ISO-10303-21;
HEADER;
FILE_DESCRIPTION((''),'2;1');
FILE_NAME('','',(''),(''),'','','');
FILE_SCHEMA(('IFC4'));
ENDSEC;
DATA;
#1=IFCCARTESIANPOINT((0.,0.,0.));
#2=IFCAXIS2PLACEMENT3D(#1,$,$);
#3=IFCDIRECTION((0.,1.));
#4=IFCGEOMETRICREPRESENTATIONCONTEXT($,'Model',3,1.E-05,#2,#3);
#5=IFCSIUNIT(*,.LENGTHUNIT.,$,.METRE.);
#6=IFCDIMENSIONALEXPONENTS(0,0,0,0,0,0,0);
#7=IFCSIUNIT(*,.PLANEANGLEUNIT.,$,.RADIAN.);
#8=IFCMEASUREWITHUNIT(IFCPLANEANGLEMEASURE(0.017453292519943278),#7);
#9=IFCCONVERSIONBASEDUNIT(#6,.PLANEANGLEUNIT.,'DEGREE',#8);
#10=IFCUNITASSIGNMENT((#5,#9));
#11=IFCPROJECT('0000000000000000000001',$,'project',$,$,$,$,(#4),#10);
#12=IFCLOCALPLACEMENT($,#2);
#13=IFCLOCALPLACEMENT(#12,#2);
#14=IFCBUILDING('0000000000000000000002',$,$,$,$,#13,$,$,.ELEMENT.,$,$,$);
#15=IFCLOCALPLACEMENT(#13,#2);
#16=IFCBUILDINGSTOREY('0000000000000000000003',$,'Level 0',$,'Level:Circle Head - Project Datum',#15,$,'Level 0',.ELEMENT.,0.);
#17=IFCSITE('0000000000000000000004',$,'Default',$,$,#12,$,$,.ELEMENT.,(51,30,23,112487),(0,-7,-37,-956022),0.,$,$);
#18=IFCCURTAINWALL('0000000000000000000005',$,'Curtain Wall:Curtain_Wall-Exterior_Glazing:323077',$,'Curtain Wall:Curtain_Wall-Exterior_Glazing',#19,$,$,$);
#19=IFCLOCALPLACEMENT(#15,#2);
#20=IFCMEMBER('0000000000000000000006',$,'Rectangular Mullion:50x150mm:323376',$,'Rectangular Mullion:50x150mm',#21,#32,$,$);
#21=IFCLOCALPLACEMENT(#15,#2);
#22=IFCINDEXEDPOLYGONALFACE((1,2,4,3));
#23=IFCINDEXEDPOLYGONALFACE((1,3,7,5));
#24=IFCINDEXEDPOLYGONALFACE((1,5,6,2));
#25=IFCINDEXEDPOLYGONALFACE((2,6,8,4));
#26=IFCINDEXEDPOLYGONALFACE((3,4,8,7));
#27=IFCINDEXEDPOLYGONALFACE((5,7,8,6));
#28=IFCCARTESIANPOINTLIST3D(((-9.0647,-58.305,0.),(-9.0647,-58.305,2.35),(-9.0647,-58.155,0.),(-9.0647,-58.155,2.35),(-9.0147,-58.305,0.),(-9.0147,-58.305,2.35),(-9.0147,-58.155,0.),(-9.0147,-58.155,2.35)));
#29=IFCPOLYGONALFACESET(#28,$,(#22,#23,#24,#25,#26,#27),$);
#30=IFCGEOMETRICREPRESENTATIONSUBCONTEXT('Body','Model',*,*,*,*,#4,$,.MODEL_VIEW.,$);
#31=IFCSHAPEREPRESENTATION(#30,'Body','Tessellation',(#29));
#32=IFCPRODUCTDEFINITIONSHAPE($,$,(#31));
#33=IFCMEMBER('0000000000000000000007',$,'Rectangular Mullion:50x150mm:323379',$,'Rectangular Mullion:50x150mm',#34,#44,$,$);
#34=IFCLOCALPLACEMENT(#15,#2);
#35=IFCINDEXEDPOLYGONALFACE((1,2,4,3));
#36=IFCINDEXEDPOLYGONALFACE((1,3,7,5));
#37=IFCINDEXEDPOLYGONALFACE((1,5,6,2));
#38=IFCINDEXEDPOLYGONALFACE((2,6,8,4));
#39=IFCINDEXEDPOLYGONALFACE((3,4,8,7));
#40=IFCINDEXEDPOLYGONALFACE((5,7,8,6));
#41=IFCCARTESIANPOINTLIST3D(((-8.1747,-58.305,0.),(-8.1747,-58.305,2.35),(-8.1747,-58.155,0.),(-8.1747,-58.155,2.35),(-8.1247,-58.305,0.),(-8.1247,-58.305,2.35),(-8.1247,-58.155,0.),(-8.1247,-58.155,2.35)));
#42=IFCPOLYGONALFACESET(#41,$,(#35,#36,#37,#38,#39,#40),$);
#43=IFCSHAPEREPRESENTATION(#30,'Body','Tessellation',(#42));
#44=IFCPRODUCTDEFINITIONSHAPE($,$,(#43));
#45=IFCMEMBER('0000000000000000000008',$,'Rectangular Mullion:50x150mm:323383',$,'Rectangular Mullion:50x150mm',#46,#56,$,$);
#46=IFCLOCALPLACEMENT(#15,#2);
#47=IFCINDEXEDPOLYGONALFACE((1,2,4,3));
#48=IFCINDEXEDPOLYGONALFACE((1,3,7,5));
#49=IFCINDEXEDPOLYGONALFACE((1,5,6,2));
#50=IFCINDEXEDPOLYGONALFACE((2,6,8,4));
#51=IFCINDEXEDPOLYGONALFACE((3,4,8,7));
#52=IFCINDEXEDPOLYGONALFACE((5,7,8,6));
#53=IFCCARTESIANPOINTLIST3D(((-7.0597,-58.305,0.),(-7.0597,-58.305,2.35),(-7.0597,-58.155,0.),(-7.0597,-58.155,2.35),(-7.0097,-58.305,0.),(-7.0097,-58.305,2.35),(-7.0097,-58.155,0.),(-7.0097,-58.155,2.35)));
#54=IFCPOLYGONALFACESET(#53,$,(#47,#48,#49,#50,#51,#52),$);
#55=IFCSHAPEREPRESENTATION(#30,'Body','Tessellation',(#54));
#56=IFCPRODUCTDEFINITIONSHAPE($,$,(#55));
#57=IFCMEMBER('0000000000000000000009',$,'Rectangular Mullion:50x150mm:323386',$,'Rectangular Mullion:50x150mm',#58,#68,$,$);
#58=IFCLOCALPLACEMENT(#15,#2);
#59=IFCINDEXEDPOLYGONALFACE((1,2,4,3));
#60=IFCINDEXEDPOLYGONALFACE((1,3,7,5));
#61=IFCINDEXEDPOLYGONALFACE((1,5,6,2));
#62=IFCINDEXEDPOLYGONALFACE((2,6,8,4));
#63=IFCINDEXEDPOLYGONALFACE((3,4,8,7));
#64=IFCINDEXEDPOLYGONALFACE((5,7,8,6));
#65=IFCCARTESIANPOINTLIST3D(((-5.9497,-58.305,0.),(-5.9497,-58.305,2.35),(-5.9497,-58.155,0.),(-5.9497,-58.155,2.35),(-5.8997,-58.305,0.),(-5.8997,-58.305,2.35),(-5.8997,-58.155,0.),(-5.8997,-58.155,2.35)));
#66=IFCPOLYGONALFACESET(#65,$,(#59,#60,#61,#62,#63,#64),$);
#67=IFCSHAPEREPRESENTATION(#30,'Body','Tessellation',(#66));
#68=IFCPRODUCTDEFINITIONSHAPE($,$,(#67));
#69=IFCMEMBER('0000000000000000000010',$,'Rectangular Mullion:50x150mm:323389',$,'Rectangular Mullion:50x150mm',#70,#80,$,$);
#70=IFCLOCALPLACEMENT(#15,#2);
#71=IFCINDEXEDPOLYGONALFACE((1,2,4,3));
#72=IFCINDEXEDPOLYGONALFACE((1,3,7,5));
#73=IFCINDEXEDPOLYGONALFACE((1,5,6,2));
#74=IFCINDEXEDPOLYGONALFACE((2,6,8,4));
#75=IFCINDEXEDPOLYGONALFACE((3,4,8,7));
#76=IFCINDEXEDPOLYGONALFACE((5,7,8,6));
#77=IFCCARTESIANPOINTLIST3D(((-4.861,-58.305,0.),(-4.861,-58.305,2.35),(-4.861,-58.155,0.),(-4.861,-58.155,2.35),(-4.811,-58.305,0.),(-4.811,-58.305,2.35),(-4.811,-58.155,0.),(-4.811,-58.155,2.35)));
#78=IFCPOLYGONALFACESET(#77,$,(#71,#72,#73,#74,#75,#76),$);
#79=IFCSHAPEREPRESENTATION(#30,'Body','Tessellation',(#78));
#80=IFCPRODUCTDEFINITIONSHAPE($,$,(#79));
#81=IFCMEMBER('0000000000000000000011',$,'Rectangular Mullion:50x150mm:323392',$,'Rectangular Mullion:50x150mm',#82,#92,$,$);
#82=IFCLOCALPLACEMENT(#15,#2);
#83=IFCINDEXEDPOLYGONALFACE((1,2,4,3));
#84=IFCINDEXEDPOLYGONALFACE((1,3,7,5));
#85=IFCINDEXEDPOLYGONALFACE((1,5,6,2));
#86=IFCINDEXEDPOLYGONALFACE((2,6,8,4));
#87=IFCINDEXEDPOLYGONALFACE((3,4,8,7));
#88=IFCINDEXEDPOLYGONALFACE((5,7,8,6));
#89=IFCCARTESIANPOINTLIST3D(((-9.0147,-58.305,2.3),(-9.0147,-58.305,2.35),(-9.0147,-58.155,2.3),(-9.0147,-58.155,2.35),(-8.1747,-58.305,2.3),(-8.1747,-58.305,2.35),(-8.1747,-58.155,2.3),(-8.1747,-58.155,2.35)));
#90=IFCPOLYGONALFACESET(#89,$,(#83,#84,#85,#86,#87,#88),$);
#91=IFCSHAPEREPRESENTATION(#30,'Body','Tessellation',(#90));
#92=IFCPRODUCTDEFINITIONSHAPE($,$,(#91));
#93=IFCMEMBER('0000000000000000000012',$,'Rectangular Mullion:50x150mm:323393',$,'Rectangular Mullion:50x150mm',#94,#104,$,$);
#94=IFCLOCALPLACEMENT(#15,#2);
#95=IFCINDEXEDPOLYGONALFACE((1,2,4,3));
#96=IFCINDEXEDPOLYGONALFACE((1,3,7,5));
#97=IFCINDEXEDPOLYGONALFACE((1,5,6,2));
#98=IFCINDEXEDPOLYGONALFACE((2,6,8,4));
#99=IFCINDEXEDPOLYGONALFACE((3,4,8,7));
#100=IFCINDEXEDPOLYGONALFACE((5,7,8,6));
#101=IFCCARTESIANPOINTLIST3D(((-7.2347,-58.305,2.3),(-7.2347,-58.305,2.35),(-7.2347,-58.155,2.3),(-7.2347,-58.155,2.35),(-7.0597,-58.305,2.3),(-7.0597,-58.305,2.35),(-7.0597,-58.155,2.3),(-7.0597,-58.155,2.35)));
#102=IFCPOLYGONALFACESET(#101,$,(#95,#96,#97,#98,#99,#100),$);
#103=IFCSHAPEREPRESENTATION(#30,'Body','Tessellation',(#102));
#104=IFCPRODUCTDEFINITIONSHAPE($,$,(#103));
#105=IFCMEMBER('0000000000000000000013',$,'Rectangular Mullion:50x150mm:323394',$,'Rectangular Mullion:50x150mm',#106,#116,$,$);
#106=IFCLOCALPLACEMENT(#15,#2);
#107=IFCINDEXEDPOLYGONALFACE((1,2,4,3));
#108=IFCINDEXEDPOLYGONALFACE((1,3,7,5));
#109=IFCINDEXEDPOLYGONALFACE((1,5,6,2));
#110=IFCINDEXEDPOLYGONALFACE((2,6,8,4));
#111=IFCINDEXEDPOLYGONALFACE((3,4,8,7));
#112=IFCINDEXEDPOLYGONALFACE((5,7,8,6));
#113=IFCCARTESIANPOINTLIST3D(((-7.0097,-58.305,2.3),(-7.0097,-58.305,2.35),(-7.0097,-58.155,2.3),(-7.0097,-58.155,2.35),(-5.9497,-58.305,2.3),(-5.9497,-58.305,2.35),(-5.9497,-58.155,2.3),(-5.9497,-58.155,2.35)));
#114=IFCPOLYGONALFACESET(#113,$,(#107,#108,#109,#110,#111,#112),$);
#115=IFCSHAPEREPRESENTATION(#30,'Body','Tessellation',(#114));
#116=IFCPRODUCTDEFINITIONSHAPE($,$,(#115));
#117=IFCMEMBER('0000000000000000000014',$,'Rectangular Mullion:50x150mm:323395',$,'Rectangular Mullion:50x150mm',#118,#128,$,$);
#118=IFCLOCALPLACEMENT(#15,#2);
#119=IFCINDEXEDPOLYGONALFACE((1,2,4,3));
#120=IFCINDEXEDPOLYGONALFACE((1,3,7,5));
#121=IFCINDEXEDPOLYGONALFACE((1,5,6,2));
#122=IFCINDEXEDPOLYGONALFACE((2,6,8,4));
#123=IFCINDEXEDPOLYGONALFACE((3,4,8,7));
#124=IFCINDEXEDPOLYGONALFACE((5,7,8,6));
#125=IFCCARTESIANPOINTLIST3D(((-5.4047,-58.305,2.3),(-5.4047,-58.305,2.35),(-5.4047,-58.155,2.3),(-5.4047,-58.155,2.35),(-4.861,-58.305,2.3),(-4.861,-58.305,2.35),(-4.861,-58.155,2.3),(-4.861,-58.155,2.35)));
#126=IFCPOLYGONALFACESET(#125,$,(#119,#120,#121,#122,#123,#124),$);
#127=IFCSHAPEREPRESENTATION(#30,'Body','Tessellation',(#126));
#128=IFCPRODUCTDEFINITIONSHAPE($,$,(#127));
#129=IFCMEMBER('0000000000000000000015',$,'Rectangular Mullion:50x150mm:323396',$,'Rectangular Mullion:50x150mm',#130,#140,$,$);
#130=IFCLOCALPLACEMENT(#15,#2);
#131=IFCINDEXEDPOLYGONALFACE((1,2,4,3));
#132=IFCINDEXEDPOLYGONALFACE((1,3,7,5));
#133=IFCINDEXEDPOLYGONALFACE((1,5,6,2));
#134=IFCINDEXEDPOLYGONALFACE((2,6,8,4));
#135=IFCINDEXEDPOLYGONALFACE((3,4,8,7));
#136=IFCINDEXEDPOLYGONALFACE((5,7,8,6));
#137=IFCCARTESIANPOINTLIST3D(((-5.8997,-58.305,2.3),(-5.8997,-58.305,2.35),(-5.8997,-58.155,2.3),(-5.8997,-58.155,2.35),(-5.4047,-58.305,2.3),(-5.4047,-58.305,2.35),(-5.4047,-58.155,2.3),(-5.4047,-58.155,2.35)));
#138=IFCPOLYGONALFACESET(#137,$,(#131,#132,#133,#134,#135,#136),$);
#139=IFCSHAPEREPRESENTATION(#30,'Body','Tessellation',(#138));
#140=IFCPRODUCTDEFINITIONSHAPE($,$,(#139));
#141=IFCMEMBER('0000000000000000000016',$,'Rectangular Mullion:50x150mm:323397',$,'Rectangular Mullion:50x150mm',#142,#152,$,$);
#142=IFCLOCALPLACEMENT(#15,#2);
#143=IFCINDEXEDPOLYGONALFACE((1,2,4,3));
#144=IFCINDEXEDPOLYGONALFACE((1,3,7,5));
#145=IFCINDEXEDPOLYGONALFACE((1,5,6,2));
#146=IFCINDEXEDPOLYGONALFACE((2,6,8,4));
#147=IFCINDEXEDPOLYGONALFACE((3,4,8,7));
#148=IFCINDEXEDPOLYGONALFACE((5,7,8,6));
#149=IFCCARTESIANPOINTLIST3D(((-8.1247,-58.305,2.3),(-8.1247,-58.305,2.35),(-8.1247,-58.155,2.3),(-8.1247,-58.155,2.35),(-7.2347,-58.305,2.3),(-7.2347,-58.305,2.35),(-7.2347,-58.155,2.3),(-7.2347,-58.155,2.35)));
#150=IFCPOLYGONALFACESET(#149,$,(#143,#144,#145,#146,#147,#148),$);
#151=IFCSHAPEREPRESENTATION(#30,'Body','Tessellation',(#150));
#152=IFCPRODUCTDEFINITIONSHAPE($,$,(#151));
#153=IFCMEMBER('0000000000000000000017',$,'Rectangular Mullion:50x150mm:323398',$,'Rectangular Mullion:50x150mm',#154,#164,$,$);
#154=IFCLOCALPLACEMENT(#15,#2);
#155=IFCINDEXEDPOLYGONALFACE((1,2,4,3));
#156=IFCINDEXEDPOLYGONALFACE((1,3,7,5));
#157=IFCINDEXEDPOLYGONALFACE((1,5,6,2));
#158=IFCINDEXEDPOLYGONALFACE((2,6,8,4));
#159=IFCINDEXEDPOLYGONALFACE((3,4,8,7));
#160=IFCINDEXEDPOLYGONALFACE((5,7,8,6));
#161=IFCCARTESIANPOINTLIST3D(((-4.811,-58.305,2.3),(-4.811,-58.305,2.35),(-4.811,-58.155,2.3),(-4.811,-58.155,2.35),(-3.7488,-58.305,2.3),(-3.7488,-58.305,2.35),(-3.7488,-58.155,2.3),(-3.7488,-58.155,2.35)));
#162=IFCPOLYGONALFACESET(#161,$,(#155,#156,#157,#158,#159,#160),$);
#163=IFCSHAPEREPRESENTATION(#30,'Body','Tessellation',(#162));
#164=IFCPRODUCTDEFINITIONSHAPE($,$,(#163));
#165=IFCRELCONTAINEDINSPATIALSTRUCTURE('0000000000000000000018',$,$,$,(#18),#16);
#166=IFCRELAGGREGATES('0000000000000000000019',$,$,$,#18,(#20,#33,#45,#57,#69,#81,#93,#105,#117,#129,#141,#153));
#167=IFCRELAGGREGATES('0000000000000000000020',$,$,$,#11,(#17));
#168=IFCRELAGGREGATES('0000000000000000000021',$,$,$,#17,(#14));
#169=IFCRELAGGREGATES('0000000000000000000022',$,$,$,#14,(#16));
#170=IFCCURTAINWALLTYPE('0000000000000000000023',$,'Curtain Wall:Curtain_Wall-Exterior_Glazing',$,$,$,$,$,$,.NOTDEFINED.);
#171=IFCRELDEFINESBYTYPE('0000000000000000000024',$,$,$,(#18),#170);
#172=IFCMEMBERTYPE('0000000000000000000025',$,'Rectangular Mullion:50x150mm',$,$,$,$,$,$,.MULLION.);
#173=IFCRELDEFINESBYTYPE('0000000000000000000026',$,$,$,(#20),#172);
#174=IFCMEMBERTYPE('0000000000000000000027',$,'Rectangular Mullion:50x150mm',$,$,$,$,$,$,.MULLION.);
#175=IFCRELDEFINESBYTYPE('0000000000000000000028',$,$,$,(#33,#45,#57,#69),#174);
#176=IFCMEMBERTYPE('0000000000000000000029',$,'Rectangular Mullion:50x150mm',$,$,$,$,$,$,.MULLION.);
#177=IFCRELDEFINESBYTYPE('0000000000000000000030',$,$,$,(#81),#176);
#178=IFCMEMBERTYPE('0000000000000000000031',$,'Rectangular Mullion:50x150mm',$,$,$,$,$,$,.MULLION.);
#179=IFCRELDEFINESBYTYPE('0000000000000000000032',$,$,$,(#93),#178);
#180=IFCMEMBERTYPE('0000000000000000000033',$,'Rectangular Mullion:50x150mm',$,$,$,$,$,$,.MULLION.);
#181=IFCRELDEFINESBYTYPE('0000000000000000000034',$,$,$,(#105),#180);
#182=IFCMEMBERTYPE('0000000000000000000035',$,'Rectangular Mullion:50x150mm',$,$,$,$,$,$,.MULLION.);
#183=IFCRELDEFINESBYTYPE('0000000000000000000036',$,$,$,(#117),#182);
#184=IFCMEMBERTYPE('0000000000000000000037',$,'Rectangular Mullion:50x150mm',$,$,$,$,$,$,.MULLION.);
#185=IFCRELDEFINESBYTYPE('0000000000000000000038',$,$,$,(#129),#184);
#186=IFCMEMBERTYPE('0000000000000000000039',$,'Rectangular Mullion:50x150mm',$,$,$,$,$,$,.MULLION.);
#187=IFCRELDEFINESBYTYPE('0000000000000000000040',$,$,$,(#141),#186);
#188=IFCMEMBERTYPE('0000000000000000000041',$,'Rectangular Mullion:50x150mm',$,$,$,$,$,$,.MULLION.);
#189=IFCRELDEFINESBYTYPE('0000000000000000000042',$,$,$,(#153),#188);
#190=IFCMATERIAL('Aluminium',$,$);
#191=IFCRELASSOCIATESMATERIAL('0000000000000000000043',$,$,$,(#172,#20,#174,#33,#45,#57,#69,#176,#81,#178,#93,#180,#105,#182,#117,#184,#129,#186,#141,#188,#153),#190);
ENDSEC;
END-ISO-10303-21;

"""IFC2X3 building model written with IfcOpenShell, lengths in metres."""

from ifc_helpers import new_model, entity, si_unit, converted_unit, direction, frame, origin, origin_2d_with_axis, place, context, subcontext, project, spatial, rectangle, extrude, source, transform, mapped, material, type_object, type_shapes, element, aggregate, save


model = new_model("IFC2X3")

# Units and contexts
model_context = context("Model", 3, precision=1e-05, world=origin(), true_north=direction((0.0, 1.0)))
body_context = subcontext(model_context, "Body", "Model", "MODEL_VIEW")
ifc_project = project(units=[si_unit("LENGTHUNIT", "METRE"), converted_unit("PLANEANGLEUNIT", "DEGREE", entity("IfcPlaneAngleMeasure", 0.017453292519943278), si_unit("PLANEANGLEUNIT", "RADIAN"), dimensions=[0, 0, 0, 0, 0, 0, 0])], contexts=[model_context])

# Site, building, storey
site_placement = place(None, origin())
site = spatial("IfcSite", under=ifc_project, at=site_placement, Name="Default", CompositionType="ELEMENT", RefLatitude=(51, 30, 23, 112487), RefLongitude=(0, -7, -37, -956022), RefElevation=0.0)
building_placement = place(site_placement, origin())
building = spatial("IfcBuilding", under=site, at=building_placement, CompositionType="ELEMENT")
storey_placement = place(building_placement, origin())
storey = spatial("IfcBuildingStorey", under=building, at=storey_placement, Name="Level 0", ObjectType="Level:Circle Head - Project Datum", LongName="Level 0", CompositionType="ELEMENT", Elevation=0.0)

# Curtain wall, members
curtain_wall_type = type_object("IfcCurtainWallType", Name="Curtain Wall:Curtain_Wall-Exterior_Glazing", PredefinedType="NOTDEFINED")
curtain_wall_placement = place(storey_placement, origin())
curtain_wall = element("IfcCurtainWall", 1, at=curtain_wall_placement, inside=storey, type_object=curtain_wall_type, Name="Curtain Wall:Curtain_Wall-Exterior_Glazing:323077", ObjectType="Curtain Wall:Curtain_Wall-Exterior_Glazing")
ifc_material_1 = material(Name="Aluminium")
member_type_1 = type_object("IfcMemberType", Name="Rectangular Mullion:50x150mm", PredefinedType="MULLION", material=ifc_material_1)
shared_shape_1 = source(origin(), body_context, "Body", "SweptSolid", [
    extrude(rectangle(XDim=0.05, YDim=0.15, at=origin_2d_with_axis()), frame((-0.025, 0.0, -2.35), z_axis=(0.0, 0.0, 1.0), x_axis=(-1.0, 0.0, 0.0)), (0.0, 0.0, 1.0), 2.35),
])
type_shapes(member_type_1, [shared_shape_1])
member_1_placement = place(curtain_wall_placement, frame((-9.0647, -58.23, 2.35), z_axis=(0.0, 0.0, 1.0), x_axis=(-1.0, 0.0, 0.0)))
member_1 = element("IfcMember", 2, at=member_1_placement, type_object=member_type_1, material=ifc_material_1, Name="Rectangular Mullion:50x150mm:323376", ObjectType="Rectangular Mullion:50x150mm", context=body_context, shape_type="MappedRepresentation", body=[
    mapped(shared_shape_1, transform((0.0, 0.0, 0.0), scale=1.0)),
])
member_type_2 = type_object("IfcMemberType", Name="Rectangular Mullion:50x150mm", PredefinedType="MULLION", material=ifc_material_1)
shared_shape_2 = source(origin(), body_context, "Body", "SweptSolid", [
    extrude(rectangle(XDim=0.05, YDim=0.15, at=origin_2d_with_axis()), frame((0.0, 0.0, -2.35), z_axis=(0.0, 0.0, 1.0), x_axis=(-1.0, 0.0, 0.0)), (0.0, 0.0, 1.0), 2.35),
])
type_shapes(member_type_2, [shared_shape_2])
member_2_placement = place(curtain_wall_placement, frame((-8.1497, -58.23, 0.0), z_axis=(0.0, 0.0, -1.0), x_axis=(1.0, 0.0, 0.0)))
member_2 = element("IfcMember", 3, at=member_2_placement, type_object=member_type_2, material=ifc_material_1, Name="Rectangular Mullion:50x150mm:323379", ObjectType="Rectangular Mullion:50x150mm", context=body_context, shape_type="MappedRepresentation", body=[
    mapped(shared_shape_2, transform((0.0, 0.0, 0.0), scale=1.0)),
])
member_3_placement = place(curtain_wall_placement, frame((-7.0347, -58.23, 0.0), z_axis=(0.0, 0.0, -1.0), x_axis=(1.0, 0.0, 0.0)))
member_3 = element("IfcMember", 4, at=member_3_placement, type_object=member_type_2, material=ifc_material_1, Name="Rectangular Mullion:50x150mm:323383", ObjectType="Rectangular Mullion:50x150mm", context=body_context, shape_type="MappedRepresentation", body=[
    mapped(shared_shape_2, transform((0.0, 0.0, 0.0), scale=1.0)),
])
member_4_placement = place(curtain_wall_placement, frame((-5.9247, -58.23, 0.0), z_axis=(0.0, 0.0, -1.0), x_axis=(1.0, 0.0, 0.0)))
member_4 = element("IfcMember", 5, at=member_4_placement, type_object=member_type_2, material=ifc_material_1, Name="Rectangular Mullion:50x150mm:323386", ObjectType="Rectangular Mullion:50x150mm", context=body_context, shape_type="MappedRepresentation", body=[
    mapped(shared_shape_2, transform((0.0, 0.0, 0.0), scale=1.0)),
])
member_5_placement = place(curtain_wall_placement, frame((-4.836, -58.23, 0.0), z_axis=(0.0, 0.0, -1.0), x_axis=(1.0, 0.0, 0.0)))
member_5 = element("IfcMember", 6, at=member_5_placement, type_object=member_type_2, material=ifc_material_1, Name="Rectangular Mullion:50x150mm:323389", ObjectType="Rectangular Mullion:50x150mm", context=body_context, shape_type="MappedRepresentation", body=[
    mapped(shared_shape_2, transform((0.0, 0.0, 0.0), scale=1.0)),
])
member_type_3 = type_object("IfcMemberType", Name="Rectangular Mullion:50x150mm", PredefinedType="MULLION", material=ifc_material_1)
shared_shape_3 = source(origin(), body_context, "Body", "SweptSolid", [
    extrude(rectangle(XDim=0.05, YDim=0.15, at=origin_2d_with_axis()), frame((-0.025, 0.0, -0.84), z_axis=(0.0, 0.0, 1.0), x_axis=(-1.0, 0.0, 0.0)), (0.0, 0.0, 1.0), 0.84),
])
type_shapes(member_type_3, [shared_shape_3])
member_6_placement = place(curtain_wall_placement, frame((-8.1747, -58.23, 2.35), z_axis=(1.0, 0.0, 0.0), x_axis=(0.0, 0.0, 1.0)))
member_6 = element("IfcMember", 7, at=member_6_placement, type_object=member_type_3, material=ifc_material_1, Name="Rectangular Mullion:50x150mm:323392", ObjectType="Rectangular Mullion:50x150mm", context=body_context, shape_type="MappedRepresentation", body=[
    mapped(shared_shape_3, transform((0.0, 0.0, 0.0), scale=1.0)),
])
member_type_4 = type_object("IfcMemberType", Name="Rectangular Mullion:50x150mm", PredefinedType="MULLION", material=ifc_material_1)
shared_shape_4 = source(origin(), body_context, "Body", "SweptSolid", [
    extrude(rectangle(XDim=0.05, YDim=0.15, at=origin_2d_with_axis()), frame((-0.025, 0.0, -0.175), z_axis=(0.0, 0.0, 1.0), x_axis=(-1.0, 0.0, 0.0)), (0.0, 0.0, 1.0), 0.175),
])
type_shapes(member_type_4, [shared_shape_4])
member_7_placement = place(curtain_wall_placement, frame((-7.0597, -58.23, 2.35), z_axis=(1.0, 0.0, 0.0), x_axis=(0.0, 0.0, 1.0)))
member_7 = element("IfcMember", 8, at=member_7_placement, type_object=member_type_4, material=ifc_material_1, Name="Rectangular Mullion:50x150mm:323393", ObjectType="Rectangular Mullion:50x150mm", context=body_context, shape_type="MappedRepresentation", body=[
    mapped(shared_shape_4, transform((0.0, 0.0, 0.0), scale=1.0)),
])
member_type_5 = type_object("IfcMemberType", Name="Rectangular Mullion:50x150mm", PredefinedType="MULLION", material=ifc_material_1)
shared_shape_5 = source(origin(), body_context, "Body", "SweptSolid", [
    extrude(rectangle(XDim=0.05, YDim=0.15, at=origin_2d_with_axis()), frame((-0.025, 0.0, -1.06), z_axis=(0.0, 0.0, 1.0), x_axis=(-1.0, 0.0, 0.0)), (0.0, 0.0, 1.0), 1.06),
])
type_shapes(member_type_5, [shared_shape_5])
member_8_placement = place(curtain_wall_placement, frame((-5.9497, -58.23, 2.35), z_axis=(1.0, 0.0, 0.0), x_axis=(0.0, 0.0, 1.0)))
member_8 = element("IfcMember", 9, at=member_8_placement, type_object=member_type_5, material=ifc_material_1, Name="Rectangular Mullion:50x150mm:323394", ObjectType="Rectangular Mullion:50x150mm", context=body_context, shape_type="MappedRepresentation", body=[
    mapped(shared_shape_5, transform((0.0, 0.0, 0.0), scale=1.0)),
])
member_type_6 = type_object("IfcMemberType", Name="Rectangular Mullion:50x150mm", PredefinedType="MULLION", material=ifc_material_1)
shared_shape_6 = source(origin(), body_context, "Body", "SweptSolid", [
    extrude(rectangle(XDim=0.05, YDim=0.15, at=origin_2d_with_axis()), frame((-0.025, 0.0, -0.5436), z_axis=(0.0, 0.0, 1.0), x_axis=(-1.0, 0.0, 0.0)), (0.0, 0.0, 1.0), 0.5436),
])
type_shapes(member_type_6, [shared_shape_6])
member_9_placement = place(curtain_wall_placement, frame((-4.861, -58.23, 2.35), z_axis=(1.0, 0.0, 0.0), x_axis=(0.0, 0.0, 1.0)))
member_9 = element("IfcMember", 10, at=member_9_placement, type_object=member_type_6, material=ifc_material_1, Name="Rectangular Mullion:50x150mm:323395", ObjectType="Rectangular Mullion:50x150mm", context=body_context, shape_type="MappedRepresentation", body=[
    mapped(shared_shape_6, transform((0.0, 0.0, 0.0), scale=1.0)),
])
member_type_7 = type_object("IfcMemberType", Name="Rectangular Mullion:50x150mm", PredefinedType="MULLION", material=ifc_material_1)
shared_shape_7 = source(origin(), body_context, "Body", "SweptSolid", [
    extrude(rectangle(XDim=0.05, YDim=0.15, at=origin_2d_with_axis()), frame((-0.025, 0.0, -0.495), z_axis=(0.0, 0.0, 1.0), x_axis=(-1.0, 0.0, 0.0)), (0.0, 0.0, 1.0), 0.495),
])
type_shapes(member_type_7, [shared_shape_7])
member_10_placement = place(curtain_wall_placement, frame((-5.4047, -58.23, 2.35), z_axis=(1.0, 0.0, 0.0), x_axis=(0.0, 0.0, 1.0)))
member_10 = element("IfcMember", 11, at=member_10_placement, type_object=member_type_7, material=ifc_material_1, Name="Rectangular Mullion:50x150mm:323396", ObjectType="Rectangular Mullion:50x150mm", context=body_context, shape_type="MappedRepresentation", body=[
    mapped(shared_shape_7, transform((0.0, 0.0, 0.0), scale=1.0)),
])
member_type_8 = type_object("IfcMemberType", Name="Rectangular Mullion:50x150mm", PredefinedType="MULLION", material=ifc_material_1)
shared_shape_8 = source(origin(), body_context, "Body", "SweptSolid", [
    extrude(rectangle(XDim=0.05, YDim=0.15, at=origin_2d_with_axis()), frame((-0.025, 0.0, -0.89), z_axis=(0.0, 0.0, 1.0), x_axis=(-1.0, 0.0, 0.0)), (0.0, 0.0, 1.0), 0.89),
])
type_shapes(member_type_8, [shared_shape_8])
member_11_placement = place(curtain_wall_placement, frame((-7.2347, -58.23, 2.35), z_axis=(1.0, 0.0, 0.0), x_axis=(0.0, 0.0, 1.0)))
member_11 = element("IfcMember", 12, at=member_11_placement, type_object=member_type_8, material=ifc_material_1, Name="Rectangular Mullion:50x150mm:323397", ObjectType="Rectangular Mullion:50x150mm", context=body_context, shape_type="MappedRepresentation", body=[
    mapped(shared_shape_8, transform((0.0, 0.0, 0.0), scale=1.0)),
])
member_type_9 = type_object("IfcMemberType", Name="Rectangular Mullion:50x150mm", PredefinedType="MULLION", material=ifc_material_1)
shared_shape_9 = source(origin(), body_context, "Body", "SweptSolid", [
    extrude(rectangle(XDim=0.05, YDim=0.15, at=origin_2d_with_axis()), frame((-0.025, 0.0, -1.0623), z_axis=(0.0, 0.0, 1.0), x_axis=(-1.0, 0.0, 0.0)), (0.0, 0.0, 1.0), 1.0623),
])
type_shapes(member_type_9, [shared_shape_9])
member_12_placement = place(curtain_wall_placement, frame((-3.7488, -58.23, 2.35), z_axis=(1.0, 0.0, 0.0), x_axis=(0.0, 0.0, 1.0)))
member_12 = element("IfcMember", 13, at=member_12_placement, type_object=member_type_9, material=ifc_material_1, Name="Rectangular Mullion:50x150mm:323398", ObjectType="Rectangular Mullion:50x150mm", context=body_context, shape_type="MappedRepresentation", body=[
    mapped(shared_shape_9, transform((0.0, 0.0, 0.0), scale=1.0)),
])
aggregate(curtain_wall, [member_1, member_2, member_3, member_4, member_5, member_6, member_7, member_8, member_9, member_10, member_11, member_12])

save(model, "model.ifc")
